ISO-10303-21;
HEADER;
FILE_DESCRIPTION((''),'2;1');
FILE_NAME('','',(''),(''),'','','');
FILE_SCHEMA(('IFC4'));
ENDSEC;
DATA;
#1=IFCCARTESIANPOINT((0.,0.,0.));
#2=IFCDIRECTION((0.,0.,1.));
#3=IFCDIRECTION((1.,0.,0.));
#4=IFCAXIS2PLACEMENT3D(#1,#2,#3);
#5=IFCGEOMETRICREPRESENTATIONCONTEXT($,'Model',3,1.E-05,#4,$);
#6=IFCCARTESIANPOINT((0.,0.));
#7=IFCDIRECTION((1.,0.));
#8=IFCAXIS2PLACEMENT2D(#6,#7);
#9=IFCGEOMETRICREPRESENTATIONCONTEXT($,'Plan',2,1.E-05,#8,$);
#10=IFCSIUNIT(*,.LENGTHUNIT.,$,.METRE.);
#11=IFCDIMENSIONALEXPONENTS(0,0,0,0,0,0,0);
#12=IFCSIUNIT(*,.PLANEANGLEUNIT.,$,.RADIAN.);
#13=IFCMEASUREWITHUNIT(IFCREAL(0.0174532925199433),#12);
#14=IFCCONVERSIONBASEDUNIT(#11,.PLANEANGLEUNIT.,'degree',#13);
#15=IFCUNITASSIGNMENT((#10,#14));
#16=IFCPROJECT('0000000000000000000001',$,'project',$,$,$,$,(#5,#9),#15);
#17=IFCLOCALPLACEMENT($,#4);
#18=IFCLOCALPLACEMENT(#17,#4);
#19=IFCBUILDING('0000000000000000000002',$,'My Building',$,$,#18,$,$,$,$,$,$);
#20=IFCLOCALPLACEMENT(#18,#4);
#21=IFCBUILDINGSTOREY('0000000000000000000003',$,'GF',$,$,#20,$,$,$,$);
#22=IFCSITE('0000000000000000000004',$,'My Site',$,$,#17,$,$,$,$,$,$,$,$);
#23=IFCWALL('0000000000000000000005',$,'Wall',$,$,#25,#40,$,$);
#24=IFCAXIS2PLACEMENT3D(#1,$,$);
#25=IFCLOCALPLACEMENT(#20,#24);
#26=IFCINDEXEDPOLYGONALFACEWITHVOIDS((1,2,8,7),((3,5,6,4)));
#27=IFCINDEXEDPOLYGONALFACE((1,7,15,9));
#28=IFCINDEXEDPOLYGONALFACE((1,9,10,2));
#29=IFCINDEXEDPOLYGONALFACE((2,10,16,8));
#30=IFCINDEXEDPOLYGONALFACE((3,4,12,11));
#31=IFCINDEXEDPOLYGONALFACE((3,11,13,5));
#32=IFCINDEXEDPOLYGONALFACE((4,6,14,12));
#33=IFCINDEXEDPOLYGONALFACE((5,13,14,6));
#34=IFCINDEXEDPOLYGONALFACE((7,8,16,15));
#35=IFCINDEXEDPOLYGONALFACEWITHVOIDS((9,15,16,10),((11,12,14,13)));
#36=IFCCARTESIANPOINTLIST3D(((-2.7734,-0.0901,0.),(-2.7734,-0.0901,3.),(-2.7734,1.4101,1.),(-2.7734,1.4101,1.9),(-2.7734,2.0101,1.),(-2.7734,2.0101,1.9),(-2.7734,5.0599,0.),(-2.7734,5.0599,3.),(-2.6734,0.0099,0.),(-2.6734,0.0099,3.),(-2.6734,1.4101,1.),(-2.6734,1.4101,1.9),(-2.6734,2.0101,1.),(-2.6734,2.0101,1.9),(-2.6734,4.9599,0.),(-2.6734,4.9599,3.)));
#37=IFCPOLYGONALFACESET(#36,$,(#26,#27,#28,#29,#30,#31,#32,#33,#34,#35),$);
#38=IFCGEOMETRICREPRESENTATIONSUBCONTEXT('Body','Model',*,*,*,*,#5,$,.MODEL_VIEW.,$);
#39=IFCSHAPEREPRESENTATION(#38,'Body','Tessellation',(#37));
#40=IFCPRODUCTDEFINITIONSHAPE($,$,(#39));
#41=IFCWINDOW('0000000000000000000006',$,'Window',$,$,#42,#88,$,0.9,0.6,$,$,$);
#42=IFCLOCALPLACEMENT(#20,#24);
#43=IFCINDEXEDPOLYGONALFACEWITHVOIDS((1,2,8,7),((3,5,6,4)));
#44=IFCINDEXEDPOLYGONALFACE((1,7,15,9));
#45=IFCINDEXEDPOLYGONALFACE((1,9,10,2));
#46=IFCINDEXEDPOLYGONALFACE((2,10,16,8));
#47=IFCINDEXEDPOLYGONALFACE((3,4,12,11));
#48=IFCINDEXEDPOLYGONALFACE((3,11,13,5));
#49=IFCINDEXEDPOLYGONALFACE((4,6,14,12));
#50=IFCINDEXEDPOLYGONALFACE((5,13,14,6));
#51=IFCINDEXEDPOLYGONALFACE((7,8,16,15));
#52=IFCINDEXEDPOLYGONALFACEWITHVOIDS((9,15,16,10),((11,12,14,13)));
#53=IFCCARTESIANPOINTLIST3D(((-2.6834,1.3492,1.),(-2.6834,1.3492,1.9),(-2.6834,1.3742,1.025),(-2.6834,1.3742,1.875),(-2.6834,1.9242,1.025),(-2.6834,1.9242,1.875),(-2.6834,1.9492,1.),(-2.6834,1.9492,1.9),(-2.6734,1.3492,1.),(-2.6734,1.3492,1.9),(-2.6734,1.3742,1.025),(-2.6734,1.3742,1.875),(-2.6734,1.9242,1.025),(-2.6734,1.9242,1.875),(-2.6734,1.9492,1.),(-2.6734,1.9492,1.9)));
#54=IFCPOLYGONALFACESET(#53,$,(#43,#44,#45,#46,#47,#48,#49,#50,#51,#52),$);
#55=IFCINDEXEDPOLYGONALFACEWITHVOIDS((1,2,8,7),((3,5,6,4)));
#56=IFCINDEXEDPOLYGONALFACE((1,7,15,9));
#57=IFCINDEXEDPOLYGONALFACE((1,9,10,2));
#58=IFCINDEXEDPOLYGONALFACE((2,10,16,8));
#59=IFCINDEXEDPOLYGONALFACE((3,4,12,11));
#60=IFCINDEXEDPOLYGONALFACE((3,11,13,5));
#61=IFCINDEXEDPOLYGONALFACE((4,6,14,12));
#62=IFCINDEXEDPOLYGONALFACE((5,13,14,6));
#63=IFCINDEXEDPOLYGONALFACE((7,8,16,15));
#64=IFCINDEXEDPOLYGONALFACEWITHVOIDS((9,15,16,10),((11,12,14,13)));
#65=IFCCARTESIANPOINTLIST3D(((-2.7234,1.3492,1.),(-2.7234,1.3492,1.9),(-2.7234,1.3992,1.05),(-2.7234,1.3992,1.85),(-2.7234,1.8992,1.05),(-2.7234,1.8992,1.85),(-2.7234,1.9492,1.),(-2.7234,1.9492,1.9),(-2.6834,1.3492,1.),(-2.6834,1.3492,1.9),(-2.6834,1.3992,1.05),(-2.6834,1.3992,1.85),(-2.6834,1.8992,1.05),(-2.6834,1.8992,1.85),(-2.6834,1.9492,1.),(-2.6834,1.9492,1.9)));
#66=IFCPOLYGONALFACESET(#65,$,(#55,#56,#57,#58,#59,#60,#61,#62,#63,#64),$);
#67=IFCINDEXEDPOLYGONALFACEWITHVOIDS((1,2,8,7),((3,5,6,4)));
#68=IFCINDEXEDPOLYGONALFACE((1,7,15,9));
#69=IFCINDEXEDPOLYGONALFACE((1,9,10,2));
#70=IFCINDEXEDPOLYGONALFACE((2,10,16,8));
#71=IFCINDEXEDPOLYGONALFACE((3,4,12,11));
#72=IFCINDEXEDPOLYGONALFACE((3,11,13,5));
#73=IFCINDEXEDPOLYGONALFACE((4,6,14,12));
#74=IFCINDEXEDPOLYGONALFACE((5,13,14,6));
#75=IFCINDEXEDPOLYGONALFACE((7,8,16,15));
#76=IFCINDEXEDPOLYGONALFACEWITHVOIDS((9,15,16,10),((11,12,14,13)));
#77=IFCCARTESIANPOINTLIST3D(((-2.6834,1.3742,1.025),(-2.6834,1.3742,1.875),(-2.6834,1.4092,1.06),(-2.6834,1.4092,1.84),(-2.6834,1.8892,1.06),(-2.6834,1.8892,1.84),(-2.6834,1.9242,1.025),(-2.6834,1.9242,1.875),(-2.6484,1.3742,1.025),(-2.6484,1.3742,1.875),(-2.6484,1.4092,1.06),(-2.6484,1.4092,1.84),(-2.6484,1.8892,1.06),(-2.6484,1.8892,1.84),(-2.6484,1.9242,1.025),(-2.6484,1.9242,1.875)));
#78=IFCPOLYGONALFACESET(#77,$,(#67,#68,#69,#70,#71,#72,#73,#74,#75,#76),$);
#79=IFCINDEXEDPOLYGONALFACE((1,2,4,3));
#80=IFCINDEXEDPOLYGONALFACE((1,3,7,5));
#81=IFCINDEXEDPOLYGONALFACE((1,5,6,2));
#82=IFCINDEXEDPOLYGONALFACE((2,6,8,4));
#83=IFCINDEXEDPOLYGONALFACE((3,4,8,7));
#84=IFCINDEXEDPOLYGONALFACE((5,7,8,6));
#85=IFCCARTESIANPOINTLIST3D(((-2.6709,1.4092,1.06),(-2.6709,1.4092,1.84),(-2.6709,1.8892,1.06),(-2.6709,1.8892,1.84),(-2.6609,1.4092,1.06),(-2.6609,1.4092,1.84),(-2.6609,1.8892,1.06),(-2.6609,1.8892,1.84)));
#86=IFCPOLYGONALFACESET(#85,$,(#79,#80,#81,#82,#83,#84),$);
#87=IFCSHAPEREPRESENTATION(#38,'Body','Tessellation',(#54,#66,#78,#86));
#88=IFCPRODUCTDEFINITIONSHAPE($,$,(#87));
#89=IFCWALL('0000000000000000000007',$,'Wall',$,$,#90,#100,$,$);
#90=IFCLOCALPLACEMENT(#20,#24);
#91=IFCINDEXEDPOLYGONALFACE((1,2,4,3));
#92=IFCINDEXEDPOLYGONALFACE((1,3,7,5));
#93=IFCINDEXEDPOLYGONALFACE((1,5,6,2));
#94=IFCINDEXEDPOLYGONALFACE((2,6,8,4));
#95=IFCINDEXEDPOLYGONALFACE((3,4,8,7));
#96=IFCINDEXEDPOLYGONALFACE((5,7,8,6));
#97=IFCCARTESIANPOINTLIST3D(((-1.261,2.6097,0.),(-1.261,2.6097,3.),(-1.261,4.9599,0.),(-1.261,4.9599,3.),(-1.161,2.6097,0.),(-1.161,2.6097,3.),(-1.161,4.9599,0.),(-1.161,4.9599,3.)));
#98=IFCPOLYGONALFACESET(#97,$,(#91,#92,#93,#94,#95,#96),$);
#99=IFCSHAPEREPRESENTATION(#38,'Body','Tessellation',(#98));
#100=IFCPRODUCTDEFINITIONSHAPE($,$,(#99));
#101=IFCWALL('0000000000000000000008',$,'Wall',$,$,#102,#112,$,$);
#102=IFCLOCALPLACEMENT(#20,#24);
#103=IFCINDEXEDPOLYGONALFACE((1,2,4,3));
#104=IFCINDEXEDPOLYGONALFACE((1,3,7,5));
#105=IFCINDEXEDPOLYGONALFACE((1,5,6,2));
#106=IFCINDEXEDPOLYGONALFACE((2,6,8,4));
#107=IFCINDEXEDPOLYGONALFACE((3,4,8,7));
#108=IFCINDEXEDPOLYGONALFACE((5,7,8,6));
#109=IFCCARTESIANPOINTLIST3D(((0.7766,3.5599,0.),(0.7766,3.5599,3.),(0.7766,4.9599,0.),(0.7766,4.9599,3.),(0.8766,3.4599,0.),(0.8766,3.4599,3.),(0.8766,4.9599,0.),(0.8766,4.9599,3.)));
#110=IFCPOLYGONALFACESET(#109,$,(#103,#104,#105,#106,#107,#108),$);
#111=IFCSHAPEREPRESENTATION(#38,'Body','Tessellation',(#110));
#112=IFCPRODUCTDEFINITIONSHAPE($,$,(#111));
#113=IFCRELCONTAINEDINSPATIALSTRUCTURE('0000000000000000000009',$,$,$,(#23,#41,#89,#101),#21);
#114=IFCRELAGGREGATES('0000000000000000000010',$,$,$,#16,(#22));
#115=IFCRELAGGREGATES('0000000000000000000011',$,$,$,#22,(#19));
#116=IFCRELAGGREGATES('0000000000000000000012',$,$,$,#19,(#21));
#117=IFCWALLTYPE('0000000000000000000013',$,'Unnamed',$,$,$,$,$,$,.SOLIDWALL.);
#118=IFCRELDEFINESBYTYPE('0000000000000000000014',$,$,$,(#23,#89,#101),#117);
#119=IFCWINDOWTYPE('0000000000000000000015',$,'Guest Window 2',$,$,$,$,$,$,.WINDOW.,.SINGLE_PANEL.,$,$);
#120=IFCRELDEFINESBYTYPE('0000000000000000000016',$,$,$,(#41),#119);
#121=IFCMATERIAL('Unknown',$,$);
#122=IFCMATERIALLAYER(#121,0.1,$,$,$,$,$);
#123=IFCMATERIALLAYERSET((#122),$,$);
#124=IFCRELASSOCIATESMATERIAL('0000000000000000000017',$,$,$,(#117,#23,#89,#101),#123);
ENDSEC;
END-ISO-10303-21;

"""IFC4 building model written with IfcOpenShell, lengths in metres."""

from ifc_helpers import new_model, entity, si_unit, converted_unit, frame, origin_with_axes, origin_2d_with_axis, place, context, subcontext, project, spatial, line, indexed_curve, outline, extrude, shape, source, transform, mapped, material, layer, layer_set, layer_usage, type_object, type_shapes, element, fill, save


model = new_model("IFC4")

# Units and contexts
model_context = context("Model", 3, precision=1e-05, world=origin_with_axes())
plan_context = context("Plan", 2, precision=1e-05, world=origin_2d_with_axis())
body_context_1 = subcontext(model_context, "Body", "Model", "MODEL_VIEW")
body_context_2 = subcontext(plan_context, "Body", "Plan", "PLAN_VIEW")
ifc_project = project(units=[si_unit("LENGTHUNIT", "METRE"), converted_unit("PLANEANGLEUNIT", "degree", entity("IfcReal", 0.0174532925199433), si_unit("PLANEANGLEUNIT", "RADIAN"), dimensions=[0, 0, 0, 0, 0, 0, 0])], contexts=[model_context, plan_context])

# Site, building, storey
site_placement = place(None, origin_with_axes())
site = spatial("IfcSite", under=ifc_project, at=site_placement, Name="My Site")
building_placement = place(site_placement, origin_with_axes())
building = spatial("IfcBuilding", under=site, at=building_placement, Name="My Building")
storey_placement = place(building_placement, origin_with_axes())
storey = spatial("IfcBuildingStorey", under=building, at=storey_placement, Name="GF")

# Shared definitions
ifc_material = material(Name="Unknown")

# Shared definitions
ifc_layer_1 = layer(ifc_material, 0.1)
ifc_layer_set_1 = layer_set([ifc_layer_1])
wall_type = type_object("IfcWallType", Name="Unnamed", PredefinedType="SOLIDWALL", material=ifc_layer_set_1)

# Wall, opening, window
ifc_layer_usage_1 = layer_usage(ifc_layer_set_1, "AXIS2", "POSITIVE", 0.0)
wall_1_placement = place(storey_placement, frame((-2.7734, 5.0599, 0.0), z_axis=(0.0, 0.0, 1.0), x_axis=(0.0, -1.0, 0.0)))
wall_1 = element("IfcWall", 1, at=wall_1_placement, inside=storey, type_object=wall_type, material=ifc_layer_usage_1, Name="Wall", context=body_context_1, shape_type="SweptSolid", body=[
    extrude(outline(indexed_curve([(0.0, 0.0), (0.1, 0.1), (5.05, 0.1), (5.15, 0.0)], segments=[line(1, 2, 3, 4, 1)])), origin_with_axes(), (0.0, 0.0, 1.0), 3.0),
])
shared_shape_1 = source(origin_with_axes(), body_context_1, "Body", "SweptSolid", [
    extrude(outline(indexed_curve([(0.0, 0.0), (0.6, 0.0), (0.6, 0.9), (0.0, 0.9)], segments=[line(1, 2, 3, 4, 1)])), frame((0.0, -0.6, 0.0), z_axis=(0.0, -1.0, 0.0), x_axis=(1.0, 0.0, 0.0)), (0.0, 0.0, -1.0), 1.2),
])
opening_1_placement = place(wall_1_placement, frame((3.0498, 0.0, 1.0), z_axis=(0.0, 0.0, 1.0), x_axis=(1.0, 0.0, 0.0)))
opening_1 = element("IfcOpeningElement", 2, at=opening_1_placement, cuts=wall_1, PredefinedType="OPENING", context=body_context_1, shape_type="MappedRepresentation", body=[
    mapped(shared_shape_1, transform((0.0, 0.0, 0.0), x_axis=(1.0, 0.0, 0.0), y_axis=(0.0, 1.0, 0.0), z_axis=(0.0, 0.0, 1.0), scale=1.0)),
])
window_type_1 = type_object("IfcWindowType", Name="Guest Window 2", PartitioningType="SINGLE_PANEL", PredefinedType="WINDOW")
shared_shape_2 = source(origin_with_axes(), body_context_1, "Body", "SweptSolid", [
    extrude(outline(indexed_curve([(0.0, 0.0), (0.6, 0.0), (0.6, 0.9), (0.0, 0.9)], segments=[line(1, 2, 3, 4, 1)]), holes=[indexed_curve([(0.025, 0.025), (0.575, 0.025), (0.575, 0.875), (0.025, 0.875)], segments=[line(1, 2, 3, 4, 1)])]), frame((0.0, 0.09, 0.0), z_axis=(0.0, -1.0, 0.0), x_axis=(1.0, 0.0, 0.0)), (0.0, 0.0, -1.0), 0.01),
    extrude(outline(indexed_curve([(0.0, 0.0), (0.6, 0.0), (0.6, 0.9), (0.0, 0.9)], segments=[line(1, 2, 3, 4, 1)]), holes=[indexed_curve([(0.05, 0.05), (0.55, 0.05), (0.55, 0.85), (0.05, 0.85)], segments=[line(1, 2, 3, 4, 1)])]), frame((0.0, 0.05, 0.0), z_axis=(0.0, -1.0, 0.0), x_axis=(1.0, 0.0, 0.0)), (0.0, 0.0, -1.0), 0.04),
    extrude(outline(indexed_curve([(0.0, 0.0), (0.55, 0.0), (0.55, 0.85), (0.0, 0.85)], segments=[line(1, 2, 3, 4, 1)]), holes=[indexed_curve([(0.035, 0.035), (0.515, 0.035), (0.515, 0.815), (0.035, 0.815)], segments=[line(1, 2, 3, 4, 1)])]), frame((0.025, 0.09, 0.025), z_axis=(0.0, -1.0, 0.0), x_axis=(1.0, 0.0, 0.0)), (0.0, 0.0, -1.0), 0.035),
    extrude(outline(indexed_curve([(0.035, 0.035), (0.515, 0.035), (0.515, 0.815), (0.035, 0.815)], segments=[line(1, 2, 3, 4, 1)])), frame((0.025, 0.1025, 0.025), z_axis=(0.0, -1.0, 0.0), x_axis=(1.0, 0.0, 0.0)), (0.0, 0.0, -1.0), 0.01),
])
shared_shape_3 = source(origin_with_axes(), body_context_2, "Body", "Curve2D", [
    entity("IfcIndexedPolyCurve", entity("IfcCartesianPointList2D", [[0.05, 0.05], [0.55, 0.05]])),
    entity("IfcIndexedPolyCurve", entity("IfcCartesianPointList2D", [[0.0, 0.1], [0.025, 0.1], [0.025, 0.09], [0.05, 0.09], [0.05, 0.05], [0.0, 0.05]]), [entity("IfcLineIndex", [1, 2, 3, 4, 5, 6, 1])]),
    entity("IfcIndexedPolyCurve", entity("IfcCartesianPointList2D", [[0.6, 0.1], [0.575, 0.1], [0.575, 0.09], [0.55, 0.09], [0.55, 0.05], [0.6, 0.05]]), [entity("IfcLineIndex", [1, 2, 3, 4, 5, 6, 1])]),
    entity("IfcIndexedPolyCurve", entity("IfcCartesianPointList2D", [[0.025, 0.09], [0.06, 0.09], [0.06, 0.125], [0.025, 0.125]]), [entity("IfcLineIndex", [1, 2, 3, 4, 1])]),
    entity("IfcIndexedPolyCurve", entity("IfcCartesianPointList2D", [[0.575, 0.09], [0.54, 0.09], [0.54, 0.125], [0.575, 0.125]]), [entity("IfcLineIndex", [1, 2, 3, 4, 1])]),
    entity("IfcIndexedPolyCurve", entity("IfcCartesianPointList2D", [[0.06, 0.09], [0.54, 0.09]])),
    entity("IfcIndexedPolyCurve", entity("IfcCartesianPointList2D", [[0.06, 0.125], [0.54, 0.125]])),
    entity("IfcIndexedPolyCurve", entity("IfcCartesianPointList2D", [[0.06, 0.1075], [0.54, 0.1075]])),
])
type_shapes(window_type_1, [shared_shape_2, shared_shape_3])
window_1_placement = place(opening_1_placement, frame((0.061, 0.0, 0.0), z_axis=(0.0, 0.0, 1.0), x_axis=(1.0, 0.0, 0.0)))
window_1 = element("IfcWindow", 3, at=window_1_placement, inside=storey, type_object=window_type_1, Name="Window", OverallHeight=0.9, OverallWidth=0.6, shapes=[
    shape(body_context_1, "Body", "MappedRepresentation", [mapped(shared_shape_2, transform((0.0, 0.0, 0.0), x_axis=(1.0, 0.0, 0.0), y_axis=(0.0, 1.0, 0.0), z_axis=(0.0, 0.0, 1.0), scale=1.0))]),
    shape(body_context_2, "Body", "MappedRepresentation", [mapped(shared_shape_3, transform((0.0, 0.0, 0.0), x_axis=(1.0, 0.0, 0.0), y_axis=(0.0, 1.0, 0.0), z_axis=(0.0, 0.0, 1.0), scale=1.0))]),
])
fill(opening_1, window_1)

# Walls
ifc_layer_usage_2 = layer_usage(ifc_layer_set_1, "AXIS2", "POSITIVE", 0.0)
wall_2_placement = place(storey_placement, frame((-1.261, 4.9599, 0.0), z_axis=(0.0, 0.0, 1.0), x_axis=(0.000037, -1.0, 0.0)))
element("IfcWall", 4, at=wall_2_placement, inside=storey, type_object=wall_type, material=ifc_layer_usage_2, Name="Wall", context=body_context_1, shape_type="SweptSolid", body=[
    extrude(outline(indexed_curve([(0.0, 0.0), (0.0, 0.1), (2.3502, 0.1), (2.3502, 0.0)], segments=[line(1, 2, 3, 4, 1)])), origin_with_axes(), (0.0, 0.0, 1.0), 3.0),
])
ifc_layer_usage_3 = layer_usage(ifc_layer_set_1, "AXIS2", "POSITIVE", 0.0)
wall_3_placement = place(storey_placement, frame((0.7766, 4.9599, 0.0), z_axis=(0.0, 0.0, 1.0), x_axis=(0.0, -1.0, 0.0)))
element("IfcWall", 5, at=wall_3_placement, inside=storey, type_object=wall_type, material=ifc_layer_usage_3, Name="Wall", context=body_context_1, shape_type="SweptSolid", body=[
    extrude(outline(indexed_curve([(0.0, 0.0), (0.0, 0.1), (1.5, 0.1), (1.4, 0.0)], segments=[line(1, 2, 3, 4, 1)])), origin_with_axes(), (0.0, 0.0, 1.0), 3.0),
])

save(model, "model.ifc")
